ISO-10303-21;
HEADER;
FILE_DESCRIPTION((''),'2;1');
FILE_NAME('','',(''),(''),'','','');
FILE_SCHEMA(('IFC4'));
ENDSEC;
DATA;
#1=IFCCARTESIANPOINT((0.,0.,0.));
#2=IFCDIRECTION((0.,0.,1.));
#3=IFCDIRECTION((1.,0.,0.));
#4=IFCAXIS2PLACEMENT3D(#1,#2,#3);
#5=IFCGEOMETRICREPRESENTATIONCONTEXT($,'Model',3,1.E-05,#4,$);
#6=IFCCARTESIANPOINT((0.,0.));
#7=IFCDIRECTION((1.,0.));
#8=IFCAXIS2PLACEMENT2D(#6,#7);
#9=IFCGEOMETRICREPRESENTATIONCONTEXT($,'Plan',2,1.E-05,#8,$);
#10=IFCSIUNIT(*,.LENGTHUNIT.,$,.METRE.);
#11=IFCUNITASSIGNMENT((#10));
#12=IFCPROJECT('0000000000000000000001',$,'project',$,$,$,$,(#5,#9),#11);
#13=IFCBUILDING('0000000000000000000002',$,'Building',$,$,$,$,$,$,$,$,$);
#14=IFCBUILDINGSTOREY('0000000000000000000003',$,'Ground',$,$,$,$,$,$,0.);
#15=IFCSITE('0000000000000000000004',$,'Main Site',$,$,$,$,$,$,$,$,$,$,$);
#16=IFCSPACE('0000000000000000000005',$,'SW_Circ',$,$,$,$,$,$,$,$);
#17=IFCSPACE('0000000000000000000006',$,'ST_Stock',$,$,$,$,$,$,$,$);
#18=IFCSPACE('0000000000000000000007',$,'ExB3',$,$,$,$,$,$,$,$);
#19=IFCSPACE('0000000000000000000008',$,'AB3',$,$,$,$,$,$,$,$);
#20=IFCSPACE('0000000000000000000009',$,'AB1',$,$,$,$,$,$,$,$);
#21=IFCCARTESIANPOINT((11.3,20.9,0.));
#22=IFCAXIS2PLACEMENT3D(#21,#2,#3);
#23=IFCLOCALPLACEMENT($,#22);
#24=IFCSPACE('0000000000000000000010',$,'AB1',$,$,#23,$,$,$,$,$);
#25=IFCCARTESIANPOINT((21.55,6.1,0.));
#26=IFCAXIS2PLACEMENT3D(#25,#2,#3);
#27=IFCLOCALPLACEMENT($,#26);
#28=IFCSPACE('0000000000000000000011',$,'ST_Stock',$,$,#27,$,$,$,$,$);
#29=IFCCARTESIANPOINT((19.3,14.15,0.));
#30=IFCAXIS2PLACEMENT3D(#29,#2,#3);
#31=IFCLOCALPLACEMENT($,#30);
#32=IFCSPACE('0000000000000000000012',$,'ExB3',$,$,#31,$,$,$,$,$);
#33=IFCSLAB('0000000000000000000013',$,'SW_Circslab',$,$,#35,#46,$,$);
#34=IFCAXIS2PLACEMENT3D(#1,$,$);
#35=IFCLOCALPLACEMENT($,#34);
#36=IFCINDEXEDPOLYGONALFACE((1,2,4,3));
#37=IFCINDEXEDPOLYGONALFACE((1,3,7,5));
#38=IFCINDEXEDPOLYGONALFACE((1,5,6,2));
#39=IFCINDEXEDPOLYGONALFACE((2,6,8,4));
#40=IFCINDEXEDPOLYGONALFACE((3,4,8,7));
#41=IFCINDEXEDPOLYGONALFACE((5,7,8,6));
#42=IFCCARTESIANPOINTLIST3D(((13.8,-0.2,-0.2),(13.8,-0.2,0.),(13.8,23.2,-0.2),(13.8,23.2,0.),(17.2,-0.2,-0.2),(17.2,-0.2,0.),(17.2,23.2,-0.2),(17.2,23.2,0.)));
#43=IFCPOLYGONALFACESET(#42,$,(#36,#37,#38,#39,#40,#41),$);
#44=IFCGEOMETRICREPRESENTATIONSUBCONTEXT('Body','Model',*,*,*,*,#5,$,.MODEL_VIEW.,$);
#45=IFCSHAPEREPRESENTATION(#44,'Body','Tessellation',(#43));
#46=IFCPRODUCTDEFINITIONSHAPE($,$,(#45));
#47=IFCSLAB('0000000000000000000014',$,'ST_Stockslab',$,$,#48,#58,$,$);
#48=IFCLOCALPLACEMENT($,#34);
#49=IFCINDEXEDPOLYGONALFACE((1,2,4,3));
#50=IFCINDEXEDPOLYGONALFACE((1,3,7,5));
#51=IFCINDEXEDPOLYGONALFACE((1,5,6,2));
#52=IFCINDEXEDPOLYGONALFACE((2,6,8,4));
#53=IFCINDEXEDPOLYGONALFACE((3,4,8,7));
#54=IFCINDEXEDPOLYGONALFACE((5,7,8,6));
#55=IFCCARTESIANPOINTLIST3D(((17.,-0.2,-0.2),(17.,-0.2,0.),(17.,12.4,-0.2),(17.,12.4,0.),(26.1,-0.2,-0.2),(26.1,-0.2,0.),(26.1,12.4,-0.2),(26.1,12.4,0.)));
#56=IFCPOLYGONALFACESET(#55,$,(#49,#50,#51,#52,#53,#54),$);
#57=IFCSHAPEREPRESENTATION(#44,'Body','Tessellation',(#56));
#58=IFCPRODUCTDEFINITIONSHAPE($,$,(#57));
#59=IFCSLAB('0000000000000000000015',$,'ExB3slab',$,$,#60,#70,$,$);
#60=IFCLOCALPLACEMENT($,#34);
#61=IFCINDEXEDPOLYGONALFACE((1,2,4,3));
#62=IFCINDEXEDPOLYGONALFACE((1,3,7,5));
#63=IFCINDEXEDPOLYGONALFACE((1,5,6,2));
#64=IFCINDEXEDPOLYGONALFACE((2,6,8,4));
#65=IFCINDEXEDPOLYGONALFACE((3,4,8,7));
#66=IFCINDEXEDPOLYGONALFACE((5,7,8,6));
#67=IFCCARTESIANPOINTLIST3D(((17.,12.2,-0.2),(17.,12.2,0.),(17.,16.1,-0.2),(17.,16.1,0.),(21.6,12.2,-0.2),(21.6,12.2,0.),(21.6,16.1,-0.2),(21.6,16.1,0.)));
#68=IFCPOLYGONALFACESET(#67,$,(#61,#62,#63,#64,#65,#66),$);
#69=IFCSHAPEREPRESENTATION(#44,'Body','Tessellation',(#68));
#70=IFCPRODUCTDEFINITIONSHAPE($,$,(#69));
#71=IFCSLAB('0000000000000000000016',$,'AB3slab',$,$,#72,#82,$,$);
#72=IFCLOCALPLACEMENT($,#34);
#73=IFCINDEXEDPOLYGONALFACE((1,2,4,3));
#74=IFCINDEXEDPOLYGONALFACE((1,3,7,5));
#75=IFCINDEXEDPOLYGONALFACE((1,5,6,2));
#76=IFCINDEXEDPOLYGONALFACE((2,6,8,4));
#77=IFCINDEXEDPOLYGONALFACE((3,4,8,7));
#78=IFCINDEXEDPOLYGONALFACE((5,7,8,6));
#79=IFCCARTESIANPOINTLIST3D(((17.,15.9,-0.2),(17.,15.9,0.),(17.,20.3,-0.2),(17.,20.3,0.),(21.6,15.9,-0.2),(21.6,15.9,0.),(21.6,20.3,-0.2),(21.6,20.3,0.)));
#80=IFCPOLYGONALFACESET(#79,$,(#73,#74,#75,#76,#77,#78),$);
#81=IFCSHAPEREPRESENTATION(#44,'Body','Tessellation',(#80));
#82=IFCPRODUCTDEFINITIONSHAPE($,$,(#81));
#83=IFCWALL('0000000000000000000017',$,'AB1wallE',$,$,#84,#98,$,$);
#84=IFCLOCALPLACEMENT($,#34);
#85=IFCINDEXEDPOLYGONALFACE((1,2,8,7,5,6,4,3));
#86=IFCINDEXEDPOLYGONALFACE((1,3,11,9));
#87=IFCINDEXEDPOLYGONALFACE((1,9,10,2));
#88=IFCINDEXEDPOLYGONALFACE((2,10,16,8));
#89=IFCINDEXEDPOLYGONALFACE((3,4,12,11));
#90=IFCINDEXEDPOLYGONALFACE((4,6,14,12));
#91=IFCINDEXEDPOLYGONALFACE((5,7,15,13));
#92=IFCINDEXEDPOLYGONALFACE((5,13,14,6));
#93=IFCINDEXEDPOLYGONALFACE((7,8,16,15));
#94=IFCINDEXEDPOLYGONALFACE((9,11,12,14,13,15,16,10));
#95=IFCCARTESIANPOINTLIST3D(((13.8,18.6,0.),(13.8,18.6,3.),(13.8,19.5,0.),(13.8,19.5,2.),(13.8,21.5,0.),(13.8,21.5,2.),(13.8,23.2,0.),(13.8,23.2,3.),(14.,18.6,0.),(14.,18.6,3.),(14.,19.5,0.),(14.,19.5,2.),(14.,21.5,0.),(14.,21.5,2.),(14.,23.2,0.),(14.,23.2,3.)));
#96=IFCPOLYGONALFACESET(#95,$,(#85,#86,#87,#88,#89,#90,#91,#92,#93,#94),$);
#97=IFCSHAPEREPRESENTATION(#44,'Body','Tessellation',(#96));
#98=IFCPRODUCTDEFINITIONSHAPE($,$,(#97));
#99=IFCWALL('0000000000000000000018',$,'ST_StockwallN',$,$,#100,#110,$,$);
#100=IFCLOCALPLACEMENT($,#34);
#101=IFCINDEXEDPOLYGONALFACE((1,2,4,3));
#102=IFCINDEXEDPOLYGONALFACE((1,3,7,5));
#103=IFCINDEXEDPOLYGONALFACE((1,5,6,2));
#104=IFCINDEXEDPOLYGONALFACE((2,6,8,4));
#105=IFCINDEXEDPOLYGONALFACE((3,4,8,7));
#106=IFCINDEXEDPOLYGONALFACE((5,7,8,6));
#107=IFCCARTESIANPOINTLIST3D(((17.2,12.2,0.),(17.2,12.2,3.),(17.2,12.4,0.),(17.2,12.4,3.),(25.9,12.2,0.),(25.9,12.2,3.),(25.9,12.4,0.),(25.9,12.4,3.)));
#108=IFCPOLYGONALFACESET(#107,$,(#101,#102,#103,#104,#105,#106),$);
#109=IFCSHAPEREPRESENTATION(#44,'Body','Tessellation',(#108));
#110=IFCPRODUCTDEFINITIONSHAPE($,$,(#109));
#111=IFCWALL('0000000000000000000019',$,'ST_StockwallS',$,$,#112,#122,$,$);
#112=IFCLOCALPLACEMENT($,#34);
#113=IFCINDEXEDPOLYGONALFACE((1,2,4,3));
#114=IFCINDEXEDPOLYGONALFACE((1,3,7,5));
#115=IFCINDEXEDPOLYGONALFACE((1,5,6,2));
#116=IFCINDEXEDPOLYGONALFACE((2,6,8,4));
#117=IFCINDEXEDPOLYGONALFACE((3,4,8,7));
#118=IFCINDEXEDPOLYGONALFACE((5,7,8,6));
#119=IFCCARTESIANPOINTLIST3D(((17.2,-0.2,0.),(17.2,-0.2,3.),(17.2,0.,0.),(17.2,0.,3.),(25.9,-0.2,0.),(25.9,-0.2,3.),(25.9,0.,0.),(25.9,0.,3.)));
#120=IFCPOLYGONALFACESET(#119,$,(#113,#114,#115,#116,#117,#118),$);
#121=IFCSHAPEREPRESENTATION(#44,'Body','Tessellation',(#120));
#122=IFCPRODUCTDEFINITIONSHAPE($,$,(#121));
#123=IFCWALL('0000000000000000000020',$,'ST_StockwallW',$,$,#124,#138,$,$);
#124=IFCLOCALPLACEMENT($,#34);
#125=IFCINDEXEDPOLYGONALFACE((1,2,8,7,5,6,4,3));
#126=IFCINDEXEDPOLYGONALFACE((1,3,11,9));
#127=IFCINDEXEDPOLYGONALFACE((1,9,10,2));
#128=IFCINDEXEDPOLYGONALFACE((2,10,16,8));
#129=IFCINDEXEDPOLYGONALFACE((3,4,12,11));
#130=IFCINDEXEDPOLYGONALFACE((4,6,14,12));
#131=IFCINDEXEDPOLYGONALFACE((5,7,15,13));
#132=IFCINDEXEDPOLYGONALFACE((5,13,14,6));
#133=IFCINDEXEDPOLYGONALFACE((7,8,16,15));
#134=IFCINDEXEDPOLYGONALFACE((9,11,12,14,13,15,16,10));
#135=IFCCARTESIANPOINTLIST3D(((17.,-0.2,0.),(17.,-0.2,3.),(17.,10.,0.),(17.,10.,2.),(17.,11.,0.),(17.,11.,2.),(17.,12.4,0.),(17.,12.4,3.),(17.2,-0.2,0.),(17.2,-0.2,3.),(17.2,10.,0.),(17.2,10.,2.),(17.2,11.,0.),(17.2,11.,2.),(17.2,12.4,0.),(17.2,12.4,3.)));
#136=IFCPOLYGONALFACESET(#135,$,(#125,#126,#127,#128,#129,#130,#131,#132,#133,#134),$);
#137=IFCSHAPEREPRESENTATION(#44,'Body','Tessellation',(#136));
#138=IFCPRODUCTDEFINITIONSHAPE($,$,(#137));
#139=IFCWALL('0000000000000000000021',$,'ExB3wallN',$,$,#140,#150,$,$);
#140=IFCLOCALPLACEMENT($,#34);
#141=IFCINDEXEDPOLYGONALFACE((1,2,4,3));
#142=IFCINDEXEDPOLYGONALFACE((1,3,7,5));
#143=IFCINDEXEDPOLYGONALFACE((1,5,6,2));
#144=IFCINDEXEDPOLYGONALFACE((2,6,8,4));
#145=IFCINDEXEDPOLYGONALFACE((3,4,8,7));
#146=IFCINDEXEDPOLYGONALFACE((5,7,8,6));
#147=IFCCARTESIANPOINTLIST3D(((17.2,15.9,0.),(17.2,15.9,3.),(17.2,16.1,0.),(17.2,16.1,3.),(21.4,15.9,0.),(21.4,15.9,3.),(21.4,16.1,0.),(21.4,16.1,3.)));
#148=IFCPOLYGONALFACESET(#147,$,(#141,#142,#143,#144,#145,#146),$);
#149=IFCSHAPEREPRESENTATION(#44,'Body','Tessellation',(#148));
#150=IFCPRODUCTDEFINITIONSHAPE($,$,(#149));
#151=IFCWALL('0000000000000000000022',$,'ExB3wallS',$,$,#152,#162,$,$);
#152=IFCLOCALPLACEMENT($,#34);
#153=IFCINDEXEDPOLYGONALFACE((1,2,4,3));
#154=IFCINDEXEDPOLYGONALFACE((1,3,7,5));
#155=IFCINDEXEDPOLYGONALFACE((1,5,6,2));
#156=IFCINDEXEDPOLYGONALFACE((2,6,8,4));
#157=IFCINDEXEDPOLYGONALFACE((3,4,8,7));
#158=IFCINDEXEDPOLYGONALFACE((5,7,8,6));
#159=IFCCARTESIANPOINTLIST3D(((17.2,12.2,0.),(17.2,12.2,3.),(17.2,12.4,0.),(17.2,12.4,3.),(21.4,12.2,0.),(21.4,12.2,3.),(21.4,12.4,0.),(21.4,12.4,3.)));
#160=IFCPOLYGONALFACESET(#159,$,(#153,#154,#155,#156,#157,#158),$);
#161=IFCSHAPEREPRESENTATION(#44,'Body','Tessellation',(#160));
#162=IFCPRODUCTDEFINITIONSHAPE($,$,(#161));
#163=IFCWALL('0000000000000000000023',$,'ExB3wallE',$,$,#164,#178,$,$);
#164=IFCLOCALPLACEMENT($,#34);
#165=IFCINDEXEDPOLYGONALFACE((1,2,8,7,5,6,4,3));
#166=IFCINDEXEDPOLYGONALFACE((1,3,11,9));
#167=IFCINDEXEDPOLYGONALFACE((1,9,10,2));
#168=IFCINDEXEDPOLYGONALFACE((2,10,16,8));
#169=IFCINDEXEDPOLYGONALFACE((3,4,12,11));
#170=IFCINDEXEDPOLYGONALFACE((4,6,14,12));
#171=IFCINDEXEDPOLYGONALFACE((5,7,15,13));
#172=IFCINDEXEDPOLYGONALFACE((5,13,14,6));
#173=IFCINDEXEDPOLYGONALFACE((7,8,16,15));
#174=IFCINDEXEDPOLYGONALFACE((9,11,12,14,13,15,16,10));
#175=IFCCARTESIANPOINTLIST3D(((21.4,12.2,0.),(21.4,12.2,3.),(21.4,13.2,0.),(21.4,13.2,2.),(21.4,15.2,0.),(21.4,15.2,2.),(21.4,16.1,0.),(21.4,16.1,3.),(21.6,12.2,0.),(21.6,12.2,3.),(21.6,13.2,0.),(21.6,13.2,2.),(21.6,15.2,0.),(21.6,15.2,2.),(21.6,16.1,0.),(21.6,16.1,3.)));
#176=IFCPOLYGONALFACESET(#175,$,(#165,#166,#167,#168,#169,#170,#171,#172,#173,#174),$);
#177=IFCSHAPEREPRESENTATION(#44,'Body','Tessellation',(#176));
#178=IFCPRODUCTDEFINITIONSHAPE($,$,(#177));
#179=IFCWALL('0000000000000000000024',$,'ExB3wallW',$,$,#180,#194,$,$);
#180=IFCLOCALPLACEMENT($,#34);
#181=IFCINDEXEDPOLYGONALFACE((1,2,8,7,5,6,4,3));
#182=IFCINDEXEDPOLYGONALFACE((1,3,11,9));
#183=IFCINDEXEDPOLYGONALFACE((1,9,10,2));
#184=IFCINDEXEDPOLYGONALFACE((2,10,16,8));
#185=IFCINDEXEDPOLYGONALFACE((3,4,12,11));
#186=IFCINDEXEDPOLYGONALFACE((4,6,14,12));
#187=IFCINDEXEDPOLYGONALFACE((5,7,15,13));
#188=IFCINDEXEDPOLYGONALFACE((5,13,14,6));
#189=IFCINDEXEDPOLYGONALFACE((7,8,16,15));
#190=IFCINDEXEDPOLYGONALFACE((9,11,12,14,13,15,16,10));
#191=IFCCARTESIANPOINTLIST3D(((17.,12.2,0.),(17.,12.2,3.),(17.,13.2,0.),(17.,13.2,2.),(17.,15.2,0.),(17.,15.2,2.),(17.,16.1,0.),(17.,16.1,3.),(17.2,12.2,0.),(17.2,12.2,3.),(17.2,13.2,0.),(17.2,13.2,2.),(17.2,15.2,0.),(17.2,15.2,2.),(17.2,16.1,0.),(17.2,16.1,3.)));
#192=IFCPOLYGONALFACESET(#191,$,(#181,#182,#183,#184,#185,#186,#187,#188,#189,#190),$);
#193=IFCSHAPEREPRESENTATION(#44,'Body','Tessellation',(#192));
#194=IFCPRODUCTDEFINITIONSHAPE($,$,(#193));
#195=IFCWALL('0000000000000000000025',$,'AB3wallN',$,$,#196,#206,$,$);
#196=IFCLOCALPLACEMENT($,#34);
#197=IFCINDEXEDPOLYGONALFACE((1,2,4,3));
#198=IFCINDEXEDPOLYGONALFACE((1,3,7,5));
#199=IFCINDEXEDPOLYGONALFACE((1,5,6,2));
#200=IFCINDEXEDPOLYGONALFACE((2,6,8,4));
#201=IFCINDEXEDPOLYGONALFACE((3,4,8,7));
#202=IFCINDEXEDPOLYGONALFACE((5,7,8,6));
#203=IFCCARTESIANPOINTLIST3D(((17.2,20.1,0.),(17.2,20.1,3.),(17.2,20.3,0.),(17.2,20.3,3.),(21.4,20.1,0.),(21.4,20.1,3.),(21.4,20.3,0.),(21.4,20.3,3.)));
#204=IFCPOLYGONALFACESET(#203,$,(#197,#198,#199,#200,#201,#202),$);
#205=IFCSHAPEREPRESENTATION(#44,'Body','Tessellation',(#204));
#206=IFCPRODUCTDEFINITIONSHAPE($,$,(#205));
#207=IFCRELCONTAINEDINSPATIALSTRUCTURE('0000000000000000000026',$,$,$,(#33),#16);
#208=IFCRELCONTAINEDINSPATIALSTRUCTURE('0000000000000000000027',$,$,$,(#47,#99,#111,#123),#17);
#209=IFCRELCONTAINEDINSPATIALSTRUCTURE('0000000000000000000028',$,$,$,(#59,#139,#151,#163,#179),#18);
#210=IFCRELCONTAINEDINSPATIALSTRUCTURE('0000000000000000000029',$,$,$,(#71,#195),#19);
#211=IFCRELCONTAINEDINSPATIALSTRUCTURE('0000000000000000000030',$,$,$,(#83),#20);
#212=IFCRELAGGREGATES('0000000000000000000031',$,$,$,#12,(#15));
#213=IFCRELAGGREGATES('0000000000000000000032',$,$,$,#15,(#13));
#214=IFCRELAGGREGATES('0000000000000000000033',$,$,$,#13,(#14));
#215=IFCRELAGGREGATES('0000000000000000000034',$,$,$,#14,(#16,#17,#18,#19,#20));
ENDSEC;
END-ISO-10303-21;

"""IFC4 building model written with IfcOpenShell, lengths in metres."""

from ifc_helpers import new_model, si_unit, frame, origin_with_axes, origin_2d_with_axis, place, context, subcontext, project, spatial, indexed_curve, rectangle, outline, extrude, element, save


model = new_model("IFC4")

# Units and contexts
model_context = context("Model", 3, precision=1e-05, world=origin_with_axes())
plan_context = context("Plan", 2, precision=1e-05, world=origin_2d_with_axis())
body_context = subcontext(model_context, "Body", "Model", "MODEL_VIEW")
ifc_project = project(units=[si_unit("LENGTHUNIT", "METRE")], contexts=[model_context, plan_context])

# Site, building, storey, space
site = spatial("IfcSite", under=ifc_project, Name="Main Site")
building = spatial("IfcBuilding", under=site, Name="Building")
storey = spatial("IfcBuildingStorey", under=building, Name="Ground", Elevation=0.0)
space_1 = spatial("IfcSpace", under=storey, Name="SW_Circ")

# Slab
slab_1_placement = place(None, frame((15.5, 11.5, -0.2), z_axis=(0.0, 0.0, 1.0), x_axis=(1.0, 0.0, 0.0)))
element("IfcSlab", 1, at=slab_1_placement, inside=space_1, Name="SW_Circslab", context=body_context, shape_type="SweptSolid", body=[
    extrude(rectangle(XDim=3.4, YDim=23.4), origin_with_axes(), (0.0, 0.0, 1.0), 0.2),
])

# Shared definitions
space_2 = spatial("IfcSpace", under=storey, Name="ST_Stock")

# Slab
slab_2_placement = place(None, frame((21.55, 6.1, -0.2), z_axis=(0.0, 0.0, 1.0), x_axis=(1.0, 0.0, 0.0)))
element("IfcSlab", 2, at=slab_2_placement, inside=space_2, Name="ST_Stockslab", context=body_context, shape_type="SweptSolid", body=[
    extrude(rectangle(XDim=9.1, YDim=12.6), origin_with_axes(), (0.0, 0.0, 1.0), 0.2),
])

# Shared definitions
space_3 = spatial("IfcSpace", under=storey, Name="ExB3")

# Slab
slab_3_placement = place(None, frame((19.3, 14.15, -0.2), z_axis=(0.0, 0.0, 1.0), x_axis=(1.0, 0.0, 0.0)))
element("IfcSlab", 3, at=slab_3_placement, inside=space_3, Name="ExB3slab", context=body_context, shape_type="SweptSolid", body=[
    extrude(rectangle(XDim=4.6, YDim=3.9), origin_with_axes(), (0.0, 0.0, 1.0), 0.2),
])

# Shared definitions
space_4 = spatial("IfcSpace", under=storey, Name="AB3")

# Slab
slab_4_placement = place(None, frame((19.3, 18.1, -0.2), z_axis=(0.0, 0.0, 1.0), x_axis=(1.0, 0.0, 0.0)))
element("IfcSlab", 4, at=slab_4_placement, inside=space_4, Name="AB3slab", context=body_context, shape_type="SweptSolid", body=[
    extrude(rectangle(XDim=4.6, YDim=4.4), origin_with_axes(), (0.0, 0.0, 1.0), 0.2),
])

# Shared definitions
space_5 = spatial("IfcSpace", under=storey, Name="AB1")

# Wall
wall_1_placement = place(None, frame((14.0, 18.6, 0.0), z_axis=(0.0, 0.0, 1.0), x_axis=(0.0, 1.0, 0.0)))
wall_1 = element("IfcWall", 5, at=wall_1_placement, inside=space_5, Name="AB1wallE", context=body_context, shape_type="SweptSolid", body=[
    extrude(outline(indexed_curve([(0.0, 0.0), (0.0, 0.2), (4.6, 0.2), (4.6, 0.0), (0.0, 0.0)], self_intersect=False)), origin_with_axes(), (0.0, 0.0, 1.0), 3.0),
])

# Shared definitions
space_6_placement = place(None, frame((11.3, 20.9, 0.0), z_axis=(0.0, 0.0, 1.0), x_axis=(1.0, 0.0, 0.0)))
space_6 = spatial("IfcSpace", at=space_6_placement, Name="AB1")

# Opening
opening_1_placement = place(wall_1_placement, frame((0.9, 0.0, 0.0), z_axis=(0.0, 0.0, 1.0), x_axis=(1.0, 0.0, 0.0)))
element("IfcOpeningElement", 6, at=opening_1_placement, inside=space_6, cuts=wall_1, context=body_context, shape_type="SweptSolid", body=[
    extrude(outline(indexed_curve([(0.0, 0.0), (0.0, 0.4), (2.0, 0.4), (2.0, 0.0), (0.0, 0.0)], self_intersect=False)), origin_with_axes(), (0.0, 0.0, 1.0), 2.0),
])

# Walls
for number, where, z_axis, x_axis, name in (
    (7, (17.2, 12.2, 0.0), (0.0, 0.0, 1.0), (1.0, 0.0, 0.0), "ST_StockwallN"),
    (8, (17.2, -0.2, 0.0), (0.0, 0.0, 1.0), (1.0, 0.0, 0.0), "ST_StockwallS"),
):
    element("IfcWall", number, at=place(None, frame(where, z_axis=z_axis, x_axis=x_axis)), inside=space_2, Name=name, context=body_context, shape_type="SweptSolid", body=[
        extrude(outline(indexed_curve([(0.0, 0.0), (0.0, 0.2), (8.7, 0.2), (8.7, 0.0), (0.0, 0.0)], self_intersect=False)), origin_with_axes(), (0.0, 0.0, 1.0), 3.0),
    ])

# Wall
wall_2_placement = place(None, frame((17.2, -0.2, 0.0), z_axis=(0.0, 0.0, 1.0), x_axis=(0.0, 1.0, 0.0)))
wall_2 = element("IfcWall", 9, at=wall_2_placement, inside=space_2, Name="ST_StockwallW", context=body_context, shape_type="SweptSolid", body=[
    extrude(outline(indexed_curve([(0.0, 0.0), (0.0, 0.2), (12.6, 0.2), (12.6, 0.0), (0.0, 0.0)], self_intersect=False)), origin_with_axes(), (0.0, 0.0, 1.0), 3.0),
])

# Shared definitions
space_7_placement = place(None, frame((21.55, 6.1, 0.0), z_axis=(0.0, 0.0, 1.0), x_axis=(1.0, 0.0, 0.0)))
space_7 = spatial("IfcSpace", at=space_7_placement, Name="ST_Stock")

# Opening
opening_2_placement = place(wall_2_placement, frame((10.2, 0.0, 0.0), z_axis=(0.0, 0.0, 1.0), x_axis=(1.0, 0.0, 0.0)))
element("IfcOpeningElement", 10, at=opening_2_placement, inside=space_7, cuts=wall_2, context=body_context, shape_type="SweptSolid", body=[
    extrude(outline(indexed_curve([(0.0, 0.0), (0.0, 0.4), (1.0, 0.4), (1.0, 0.0), (0.0, 0.0)], self_intersect=False)), origin_with_axes(), (0.0, 0.0, 1.0), 2.0),
])

# Walls
for number, where, z_axis, x_axis, name in (
    (11, (17.2, 15.9, 0.0), (0.0, 0.0, 1.0), (1.0, 0.0, 0.0), "ExB3wallN"),
    (12, (17.2, 12.2, 0.0), (0.0, 0.0, 1.0), (1.0, 0.0, 0.0), "ExB3wallS"),
):
    element("IfcWall", number, at=place(None, frame(where, z_axis=z_axis, x_axis=x_axis)), inside=space_3, Name=name, context=body_context, shape_type="SweptSolid", body=[
        extrude(outline(indexed_curve([(0.0, 0.0), (0.0, 0.2), (4.2, 0.2), (4.2, 0.0), (0.0, 0.0)], self_intersect=False)), origin_with_axes(), (0.0, 0.0, 1.0), 3.0),
    ])

# Wall
wall_3_placement = place(None, frame((21.6, 12.2, 0.0), z_axis=(0.0, 0.0, 1.0), x_axis=(0.0, 1.0, 0.0)))
wall_3 = element("IfcWall", 13, at=wall_3_placement, inside=space_3, Name="ExB3wallE", context=body_context, shape_type="SweptSolid", body=[
    extrude(outline(indexed_curve([(0.0, 0.0), (0.0, 0.2), (3.9, 0.2), (3.9, 0.0), (0.0, 0.0)], self_intersect=False)), origin_with_axes(), (0.0, 0.0, 1.0), 3.0),
])

# Shared definitions
space_8_placement = place(None, frame((19.3, 14.15, 0.0), z_axis=(0.0, 0.0, 1.0), x_axis=(1.0, 0.0, 0.0)))
space_8 = spatial("IfcSpace", at=space_8_placement, Name="ExB3")

# Opening
opening_3_placement = place(wall_3_placement, frame((1.0, 0.0, 0.0), z_axis=(0.0, 0.0, 1.0), x_axis=(1.0, 0.0, 0.0)))
element("IfcOpeningElement", 14, at=opening_3_placement, inside=space_8, cuts=wall_3, context=body_context, shape_type="SweptSolid", body=[
    extrude(outline(indexed_curve([(0.0, 0.0), (0.0, 0.4), (2.0, 0.4), (2.0, 0.0), (0.0, 0.0)], self_intersect=False)), origin_with_axes(), (0.0, 0.0, 1.0), 2.0),
])

# Wall, opening
wall_4_placement = place(None, frame((17.2, 12.2, 0.0), z_axis=(0.0, 0.0, 1.0), x_axis=(0.0, 1.0, 0.0)))
wall_4 = element("IfcWall", 15, at=wall_4_placement, inside=space_3, Name="ExB3wallW", context=body_context, shape_type="SweptSolid", body=[
    extrude(outline(indexed_curve([(0.0, 0.0), (0.0, 0.2), (3.9, 0.2), (3.9, 0.0), (0.0, 0.0)], self_intersect=False)), origin_with_axes(), (0.0, 0.0, 1.0), 3.0),
])
opening_4_placement = place(wall_4_placement, frame((1.0, 0.0, 0.0), z_axis=(0.0, 0.0, 1.0), x_axis=(1.0, 0.0, 0.0)))
element("IfcOpeningElement", 16, at=opening_4_placement, inside=space_8, cuts=wall_4, context=body_context, shape_type="SweptSolid", body=[
    extrude(outline(indexed_curve([(0.0, 0.0), (0.0, 0.4), (2.0, 0.4), (2.0, 0.0), (0.0, 0.0)], self_intersect=False)), origin_with_axes(), (0.0, 0.0, 1.0), 2.0),
])

# Wall
for number, where, z_axis, x_axis, name in (
    (17, (17.2, 20.1, 0.0), (0.0, 0.0, 1.0), (1.0, 0.0, 0.0), "AB3wallN"),
):
    element("IfcWall", number, at=place(None, frame(where, z_axis=z_axis, x_axis=x_axis)), inside=space_4, Name=name, context=body_context, shape_type="SweptSolid", body=[
        extrude(outline(indexed_curve([(0.0, 0.0), (0.0, 0.2), (4.2, 0.2), (4.2, 0.0), (0.0, 0.0)], self_intersect=False)), origin_with_axes(), (0.0, 0.0, 1.0), 3.0),
    ])

save(model, "model.ifc")
